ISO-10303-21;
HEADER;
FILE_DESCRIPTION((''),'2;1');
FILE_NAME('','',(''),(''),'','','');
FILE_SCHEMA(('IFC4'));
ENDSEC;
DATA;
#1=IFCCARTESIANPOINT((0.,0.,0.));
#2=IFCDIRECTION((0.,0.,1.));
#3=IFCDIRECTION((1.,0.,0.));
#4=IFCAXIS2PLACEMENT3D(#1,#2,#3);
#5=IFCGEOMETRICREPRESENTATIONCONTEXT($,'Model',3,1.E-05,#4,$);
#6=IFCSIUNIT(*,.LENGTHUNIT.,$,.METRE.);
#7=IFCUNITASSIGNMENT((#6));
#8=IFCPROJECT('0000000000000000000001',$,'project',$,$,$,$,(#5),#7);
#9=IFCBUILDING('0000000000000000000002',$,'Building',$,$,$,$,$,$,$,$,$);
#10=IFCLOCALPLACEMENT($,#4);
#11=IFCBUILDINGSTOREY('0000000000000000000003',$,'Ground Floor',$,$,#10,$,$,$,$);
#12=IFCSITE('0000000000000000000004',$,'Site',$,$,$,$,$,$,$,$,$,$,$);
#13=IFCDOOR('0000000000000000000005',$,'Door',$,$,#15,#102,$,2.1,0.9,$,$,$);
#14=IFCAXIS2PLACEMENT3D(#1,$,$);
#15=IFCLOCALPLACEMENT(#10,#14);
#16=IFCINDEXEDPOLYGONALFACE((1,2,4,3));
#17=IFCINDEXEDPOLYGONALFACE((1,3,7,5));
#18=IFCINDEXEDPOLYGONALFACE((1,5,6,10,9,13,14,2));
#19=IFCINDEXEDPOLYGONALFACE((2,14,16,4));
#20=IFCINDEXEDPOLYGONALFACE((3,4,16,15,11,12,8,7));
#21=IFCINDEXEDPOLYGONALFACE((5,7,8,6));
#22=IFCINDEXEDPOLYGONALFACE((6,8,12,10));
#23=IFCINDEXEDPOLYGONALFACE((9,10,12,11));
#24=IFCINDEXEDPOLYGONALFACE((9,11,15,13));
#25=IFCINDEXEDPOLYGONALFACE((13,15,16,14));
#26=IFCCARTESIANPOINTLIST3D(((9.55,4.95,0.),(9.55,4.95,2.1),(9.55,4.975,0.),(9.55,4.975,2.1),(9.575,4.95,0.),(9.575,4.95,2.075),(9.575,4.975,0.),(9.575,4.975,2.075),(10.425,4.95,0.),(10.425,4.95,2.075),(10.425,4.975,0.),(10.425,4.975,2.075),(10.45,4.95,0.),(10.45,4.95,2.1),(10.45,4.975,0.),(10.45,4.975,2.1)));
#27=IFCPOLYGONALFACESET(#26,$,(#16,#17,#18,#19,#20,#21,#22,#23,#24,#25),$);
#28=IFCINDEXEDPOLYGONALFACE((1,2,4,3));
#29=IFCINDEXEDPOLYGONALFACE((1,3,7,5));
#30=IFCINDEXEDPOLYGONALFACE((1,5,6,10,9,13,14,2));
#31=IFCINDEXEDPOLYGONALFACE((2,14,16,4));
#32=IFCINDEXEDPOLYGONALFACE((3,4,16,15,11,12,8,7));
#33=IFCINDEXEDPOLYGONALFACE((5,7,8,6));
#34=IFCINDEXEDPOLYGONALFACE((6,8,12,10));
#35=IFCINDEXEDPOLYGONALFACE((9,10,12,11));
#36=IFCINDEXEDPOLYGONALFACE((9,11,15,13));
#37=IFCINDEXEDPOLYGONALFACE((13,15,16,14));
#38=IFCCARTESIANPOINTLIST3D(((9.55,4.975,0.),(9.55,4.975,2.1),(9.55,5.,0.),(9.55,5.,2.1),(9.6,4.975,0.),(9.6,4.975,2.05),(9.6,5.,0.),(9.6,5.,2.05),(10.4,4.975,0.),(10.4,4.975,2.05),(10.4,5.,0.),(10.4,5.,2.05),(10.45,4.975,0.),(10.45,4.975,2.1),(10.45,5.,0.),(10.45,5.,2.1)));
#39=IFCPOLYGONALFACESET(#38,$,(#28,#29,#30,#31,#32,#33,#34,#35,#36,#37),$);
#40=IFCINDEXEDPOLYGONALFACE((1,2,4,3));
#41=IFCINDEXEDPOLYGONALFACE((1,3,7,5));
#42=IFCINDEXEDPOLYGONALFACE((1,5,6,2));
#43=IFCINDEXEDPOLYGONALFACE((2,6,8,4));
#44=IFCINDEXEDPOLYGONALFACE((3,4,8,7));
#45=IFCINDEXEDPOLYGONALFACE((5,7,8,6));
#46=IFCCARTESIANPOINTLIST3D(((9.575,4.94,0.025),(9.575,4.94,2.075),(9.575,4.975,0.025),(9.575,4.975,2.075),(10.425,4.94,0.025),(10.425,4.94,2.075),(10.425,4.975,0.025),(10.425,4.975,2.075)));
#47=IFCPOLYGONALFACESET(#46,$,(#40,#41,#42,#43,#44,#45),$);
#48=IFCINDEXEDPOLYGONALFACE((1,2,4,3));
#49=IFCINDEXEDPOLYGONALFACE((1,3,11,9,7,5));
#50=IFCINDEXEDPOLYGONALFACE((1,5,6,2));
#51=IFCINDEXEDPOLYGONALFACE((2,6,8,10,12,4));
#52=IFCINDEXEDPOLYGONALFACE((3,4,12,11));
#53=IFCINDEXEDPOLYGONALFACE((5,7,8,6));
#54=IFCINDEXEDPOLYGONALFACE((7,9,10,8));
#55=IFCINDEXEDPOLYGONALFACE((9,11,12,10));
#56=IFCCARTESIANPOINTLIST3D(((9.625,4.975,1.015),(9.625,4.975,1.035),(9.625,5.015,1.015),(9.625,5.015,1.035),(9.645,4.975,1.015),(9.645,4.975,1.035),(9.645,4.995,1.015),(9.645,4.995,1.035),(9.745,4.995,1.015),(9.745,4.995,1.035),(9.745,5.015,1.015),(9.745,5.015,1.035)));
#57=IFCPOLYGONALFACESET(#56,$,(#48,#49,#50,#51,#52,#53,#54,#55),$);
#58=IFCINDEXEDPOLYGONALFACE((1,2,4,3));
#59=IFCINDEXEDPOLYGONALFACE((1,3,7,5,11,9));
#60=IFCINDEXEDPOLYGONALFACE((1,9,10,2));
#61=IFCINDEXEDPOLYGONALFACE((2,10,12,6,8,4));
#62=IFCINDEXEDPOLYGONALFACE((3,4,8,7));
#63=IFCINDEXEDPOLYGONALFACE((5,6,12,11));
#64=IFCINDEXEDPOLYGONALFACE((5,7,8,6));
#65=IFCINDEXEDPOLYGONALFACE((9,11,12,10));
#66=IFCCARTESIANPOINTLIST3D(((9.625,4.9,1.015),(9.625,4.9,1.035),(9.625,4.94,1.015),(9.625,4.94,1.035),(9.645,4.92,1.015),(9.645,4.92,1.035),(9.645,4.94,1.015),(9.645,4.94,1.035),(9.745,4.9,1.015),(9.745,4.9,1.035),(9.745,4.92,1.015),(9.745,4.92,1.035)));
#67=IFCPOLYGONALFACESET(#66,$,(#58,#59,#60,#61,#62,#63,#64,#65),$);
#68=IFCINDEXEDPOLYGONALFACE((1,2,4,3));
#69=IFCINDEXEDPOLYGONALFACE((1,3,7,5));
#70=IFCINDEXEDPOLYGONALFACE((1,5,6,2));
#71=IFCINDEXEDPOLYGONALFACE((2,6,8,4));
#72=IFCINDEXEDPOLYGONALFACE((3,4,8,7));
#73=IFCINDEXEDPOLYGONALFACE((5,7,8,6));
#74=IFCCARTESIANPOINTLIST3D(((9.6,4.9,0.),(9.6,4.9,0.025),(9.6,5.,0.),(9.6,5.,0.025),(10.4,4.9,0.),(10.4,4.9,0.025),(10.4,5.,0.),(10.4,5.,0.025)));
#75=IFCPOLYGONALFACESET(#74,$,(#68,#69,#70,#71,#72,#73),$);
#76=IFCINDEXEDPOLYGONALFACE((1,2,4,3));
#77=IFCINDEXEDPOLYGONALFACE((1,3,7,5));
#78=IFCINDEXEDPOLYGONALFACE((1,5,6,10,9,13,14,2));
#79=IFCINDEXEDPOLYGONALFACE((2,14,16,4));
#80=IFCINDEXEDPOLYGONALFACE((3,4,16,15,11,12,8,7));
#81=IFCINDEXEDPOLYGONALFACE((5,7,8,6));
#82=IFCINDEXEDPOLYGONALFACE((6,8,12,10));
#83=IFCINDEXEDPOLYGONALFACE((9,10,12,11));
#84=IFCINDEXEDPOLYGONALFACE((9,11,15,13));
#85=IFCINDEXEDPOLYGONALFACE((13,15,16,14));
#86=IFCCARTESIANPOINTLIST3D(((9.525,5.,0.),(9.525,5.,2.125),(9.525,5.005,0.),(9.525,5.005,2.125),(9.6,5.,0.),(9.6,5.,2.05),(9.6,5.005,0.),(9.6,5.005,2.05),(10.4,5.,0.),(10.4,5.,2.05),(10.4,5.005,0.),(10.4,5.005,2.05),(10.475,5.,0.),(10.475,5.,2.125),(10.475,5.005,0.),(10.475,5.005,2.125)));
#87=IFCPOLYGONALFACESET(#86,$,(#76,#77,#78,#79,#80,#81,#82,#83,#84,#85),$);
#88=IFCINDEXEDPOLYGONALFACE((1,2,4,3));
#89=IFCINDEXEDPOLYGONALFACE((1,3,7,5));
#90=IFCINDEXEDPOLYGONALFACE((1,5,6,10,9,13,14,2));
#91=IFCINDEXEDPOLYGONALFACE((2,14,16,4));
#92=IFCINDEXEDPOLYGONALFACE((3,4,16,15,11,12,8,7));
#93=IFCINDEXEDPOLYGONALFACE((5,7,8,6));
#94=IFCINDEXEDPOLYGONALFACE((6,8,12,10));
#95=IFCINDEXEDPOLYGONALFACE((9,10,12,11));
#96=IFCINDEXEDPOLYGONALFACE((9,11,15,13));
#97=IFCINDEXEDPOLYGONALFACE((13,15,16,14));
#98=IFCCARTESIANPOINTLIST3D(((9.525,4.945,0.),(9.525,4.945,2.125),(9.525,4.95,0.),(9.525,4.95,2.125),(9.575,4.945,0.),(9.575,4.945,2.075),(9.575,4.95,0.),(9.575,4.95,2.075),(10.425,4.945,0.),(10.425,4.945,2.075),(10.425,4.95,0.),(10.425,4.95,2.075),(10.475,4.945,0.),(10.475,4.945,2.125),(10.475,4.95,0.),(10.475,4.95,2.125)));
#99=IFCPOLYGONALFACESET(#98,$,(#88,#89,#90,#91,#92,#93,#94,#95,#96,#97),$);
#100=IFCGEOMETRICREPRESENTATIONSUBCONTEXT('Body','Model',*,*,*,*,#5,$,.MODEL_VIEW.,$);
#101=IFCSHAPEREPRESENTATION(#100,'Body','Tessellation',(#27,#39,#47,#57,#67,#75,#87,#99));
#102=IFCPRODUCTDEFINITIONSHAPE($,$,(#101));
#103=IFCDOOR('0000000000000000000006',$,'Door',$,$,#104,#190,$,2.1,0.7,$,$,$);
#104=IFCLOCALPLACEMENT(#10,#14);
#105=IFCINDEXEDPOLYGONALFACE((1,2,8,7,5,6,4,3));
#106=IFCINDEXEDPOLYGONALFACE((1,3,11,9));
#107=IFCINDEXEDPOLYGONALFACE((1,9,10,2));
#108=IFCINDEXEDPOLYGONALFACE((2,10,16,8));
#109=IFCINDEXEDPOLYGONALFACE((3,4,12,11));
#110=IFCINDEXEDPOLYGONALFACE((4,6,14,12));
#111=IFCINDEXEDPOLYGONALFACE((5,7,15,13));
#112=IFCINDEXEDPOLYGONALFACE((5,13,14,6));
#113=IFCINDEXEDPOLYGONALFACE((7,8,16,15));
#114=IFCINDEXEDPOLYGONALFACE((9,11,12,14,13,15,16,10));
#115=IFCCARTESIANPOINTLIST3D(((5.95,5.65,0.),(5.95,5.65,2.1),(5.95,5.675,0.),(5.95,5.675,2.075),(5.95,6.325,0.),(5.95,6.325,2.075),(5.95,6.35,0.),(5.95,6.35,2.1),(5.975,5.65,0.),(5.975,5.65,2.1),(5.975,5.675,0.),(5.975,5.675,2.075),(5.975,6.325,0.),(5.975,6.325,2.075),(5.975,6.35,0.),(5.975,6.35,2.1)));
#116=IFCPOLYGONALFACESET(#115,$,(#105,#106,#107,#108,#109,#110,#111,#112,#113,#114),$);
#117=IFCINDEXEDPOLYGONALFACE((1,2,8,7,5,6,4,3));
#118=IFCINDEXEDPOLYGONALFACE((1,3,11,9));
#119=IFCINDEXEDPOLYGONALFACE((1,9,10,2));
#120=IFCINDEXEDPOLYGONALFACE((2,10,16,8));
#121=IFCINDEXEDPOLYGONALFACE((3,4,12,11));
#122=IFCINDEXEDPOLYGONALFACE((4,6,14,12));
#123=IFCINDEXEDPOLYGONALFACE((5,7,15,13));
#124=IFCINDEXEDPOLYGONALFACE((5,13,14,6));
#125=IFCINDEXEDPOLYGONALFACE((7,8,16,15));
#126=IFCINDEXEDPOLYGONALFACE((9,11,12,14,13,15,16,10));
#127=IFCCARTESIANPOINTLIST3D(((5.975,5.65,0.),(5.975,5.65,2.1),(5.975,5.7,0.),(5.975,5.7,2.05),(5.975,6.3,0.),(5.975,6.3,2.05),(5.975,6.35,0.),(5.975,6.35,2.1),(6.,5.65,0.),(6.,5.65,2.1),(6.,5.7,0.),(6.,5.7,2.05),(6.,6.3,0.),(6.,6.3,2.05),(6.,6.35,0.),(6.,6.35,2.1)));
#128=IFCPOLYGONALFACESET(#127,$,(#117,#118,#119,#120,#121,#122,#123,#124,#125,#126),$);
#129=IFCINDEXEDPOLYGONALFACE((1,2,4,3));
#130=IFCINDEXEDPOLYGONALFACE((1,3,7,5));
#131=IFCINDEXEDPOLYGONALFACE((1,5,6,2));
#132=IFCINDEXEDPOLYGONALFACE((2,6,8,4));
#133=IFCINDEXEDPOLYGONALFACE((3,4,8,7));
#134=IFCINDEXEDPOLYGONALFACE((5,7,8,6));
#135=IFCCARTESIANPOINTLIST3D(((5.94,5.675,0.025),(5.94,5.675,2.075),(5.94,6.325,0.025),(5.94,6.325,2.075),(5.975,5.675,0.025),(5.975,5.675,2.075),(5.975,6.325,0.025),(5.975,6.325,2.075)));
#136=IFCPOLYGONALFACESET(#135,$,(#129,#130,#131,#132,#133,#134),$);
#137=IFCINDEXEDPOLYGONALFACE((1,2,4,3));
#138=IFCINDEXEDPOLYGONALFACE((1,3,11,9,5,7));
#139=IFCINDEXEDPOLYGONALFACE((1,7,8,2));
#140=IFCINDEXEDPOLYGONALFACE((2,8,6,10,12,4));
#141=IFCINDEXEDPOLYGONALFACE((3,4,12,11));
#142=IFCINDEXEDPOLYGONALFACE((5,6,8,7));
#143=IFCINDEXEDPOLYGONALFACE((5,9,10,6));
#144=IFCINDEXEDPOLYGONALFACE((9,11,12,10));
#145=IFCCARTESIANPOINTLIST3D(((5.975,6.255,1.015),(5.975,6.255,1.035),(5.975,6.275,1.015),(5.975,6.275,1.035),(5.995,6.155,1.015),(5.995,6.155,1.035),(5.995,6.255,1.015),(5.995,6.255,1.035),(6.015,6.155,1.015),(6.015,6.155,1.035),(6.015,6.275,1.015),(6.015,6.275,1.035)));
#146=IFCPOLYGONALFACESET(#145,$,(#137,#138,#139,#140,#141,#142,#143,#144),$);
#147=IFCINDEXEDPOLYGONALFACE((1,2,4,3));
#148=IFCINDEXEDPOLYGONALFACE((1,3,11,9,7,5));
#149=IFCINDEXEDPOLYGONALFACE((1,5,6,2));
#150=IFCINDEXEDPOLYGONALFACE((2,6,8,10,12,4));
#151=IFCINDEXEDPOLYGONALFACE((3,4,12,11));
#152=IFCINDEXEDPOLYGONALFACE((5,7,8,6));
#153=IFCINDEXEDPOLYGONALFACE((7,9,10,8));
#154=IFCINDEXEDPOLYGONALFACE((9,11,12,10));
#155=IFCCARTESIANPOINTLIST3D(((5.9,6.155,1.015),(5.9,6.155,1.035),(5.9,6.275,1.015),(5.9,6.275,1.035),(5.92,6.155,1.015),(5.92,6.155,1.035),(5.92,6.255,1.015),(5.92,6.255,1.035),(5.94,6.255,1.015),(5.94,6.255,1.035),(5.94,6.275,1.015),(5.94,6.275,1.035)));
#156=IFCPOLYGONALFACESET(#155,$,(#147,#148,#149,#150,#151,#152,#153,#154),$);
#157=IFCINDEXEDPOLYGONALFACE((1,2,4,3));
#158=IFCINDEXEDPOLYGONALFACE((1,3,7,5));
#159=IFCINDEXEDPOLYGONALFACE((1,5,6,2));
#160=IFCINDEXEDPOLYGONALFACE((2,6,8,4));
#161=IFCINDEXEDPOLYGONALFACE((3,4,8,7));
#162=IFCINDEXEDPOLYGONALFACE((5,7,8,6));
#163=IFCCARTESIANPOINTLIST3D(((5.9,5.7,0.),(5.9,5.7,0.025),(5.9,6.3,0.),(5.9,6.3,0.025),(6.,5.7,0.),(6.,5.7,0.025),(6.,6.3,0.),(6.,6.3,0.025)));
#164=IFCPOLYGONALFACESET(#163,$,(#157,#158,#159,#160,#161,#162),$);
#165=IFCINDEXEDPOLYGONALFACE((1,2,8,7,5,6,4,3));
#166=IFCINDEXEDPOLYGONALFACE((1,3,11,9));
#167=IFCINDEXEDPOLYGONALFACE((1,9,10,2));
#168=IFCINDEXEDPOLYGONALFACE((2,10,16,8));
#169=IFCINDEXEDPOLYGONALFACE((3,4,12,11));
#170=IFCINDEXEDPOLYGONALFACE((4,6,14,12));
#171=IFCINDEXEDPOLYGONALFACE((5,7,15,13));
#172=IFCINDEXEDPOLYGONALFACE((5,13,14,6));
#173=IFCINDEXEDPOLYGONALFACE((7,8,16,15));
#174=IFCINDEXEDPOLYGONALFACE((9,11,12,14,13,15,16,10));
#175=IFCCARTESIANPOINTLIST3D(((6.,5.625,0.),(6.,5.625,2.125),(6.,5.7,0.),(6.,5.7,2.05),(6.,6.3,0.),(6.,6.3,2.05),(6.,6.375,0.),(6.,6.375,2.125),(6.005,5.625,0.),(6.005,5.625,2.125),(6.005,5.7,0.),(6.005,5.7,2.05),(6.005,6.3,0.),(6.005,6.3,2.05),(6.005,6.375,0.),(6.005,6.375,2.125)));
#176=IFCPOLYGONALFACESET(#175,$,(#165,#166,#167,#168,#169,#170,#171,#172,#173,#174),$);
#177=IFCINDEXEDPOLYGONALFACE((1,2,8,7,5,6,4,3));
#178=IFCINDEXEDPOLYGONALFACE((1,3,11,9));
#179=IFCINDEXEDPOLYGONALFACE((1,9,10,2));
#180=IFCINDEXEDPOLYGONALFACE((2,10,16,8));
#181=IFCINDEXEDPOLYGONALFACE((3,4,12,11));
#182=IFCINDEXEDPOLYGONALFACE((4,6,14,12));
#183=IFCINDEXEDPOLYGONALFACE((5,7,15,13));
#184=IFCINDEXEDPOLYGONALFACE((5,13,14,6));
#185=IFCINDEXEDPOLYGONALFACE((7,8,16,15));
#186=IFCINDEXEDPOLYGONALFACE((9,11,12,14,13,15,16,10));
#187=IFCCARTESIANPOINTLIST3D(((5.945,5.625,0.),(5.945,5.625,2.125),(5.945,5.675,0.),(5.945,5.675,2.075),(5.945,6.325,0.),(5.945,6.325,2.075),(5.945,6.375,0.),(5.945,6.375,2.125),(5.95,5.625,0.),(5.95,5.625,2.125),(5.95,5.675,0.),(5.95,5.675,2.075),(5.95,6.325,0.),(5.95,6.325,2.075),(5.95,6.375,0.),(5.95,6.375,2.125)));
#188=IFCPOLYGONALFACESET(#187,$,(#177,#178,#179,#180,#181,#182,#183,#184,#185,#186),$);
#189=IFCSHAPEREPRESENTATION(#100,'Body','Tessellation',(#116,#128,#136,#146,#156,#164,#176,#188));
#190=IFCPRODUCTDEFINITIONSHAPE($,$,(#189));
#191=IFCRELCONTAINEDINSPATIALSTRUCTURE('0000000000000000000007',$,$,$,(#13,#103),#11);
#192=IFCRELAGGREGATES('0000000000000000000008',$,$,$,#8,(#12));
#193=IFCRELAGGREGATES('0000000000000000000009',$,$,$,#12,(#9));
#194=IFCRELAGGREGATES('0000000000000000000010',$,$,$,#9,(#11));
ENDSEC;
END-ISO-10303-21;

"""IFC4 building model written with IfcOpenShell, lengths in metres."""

from ifc_helpers import new_model, si_unit, frame, origin_with_axes, place, context, subcontext, project, spatial, line, indexed_curve, outline, extrude, element, save


model = new_model("IFC4")

# Units and contexts
model_context = context("Model", 3, precision=1e-05, world=origin_with_axes())
body_context = subcontext(model_context, "Body", "Model", "MODEL_VIEW")
ifc_project = project(units=[si_unit("LENGTHUNIT", "METRE")], contexts=[model_context])

# Site, building, storey
site = spatial("IfcSite", under=ifc_project, Name="Site")
building = spatial("IfcBuilding", under=site, Name="Building")
storey_placement = place(None, origin_with_axes())
storey = spatial("IfcBuildingStorey", under=building, at=storey_placement, Name="Ground Floor")

# Doors
door_1_placement = place(storey_placement, frame((10.45, 5.0, 0.0), z_axis=(0.0, 0.0, 1.0), x_axis=(-1.0, 0.0, 0.0)))
element("IfcDoor", 1, at=door_1_placement, inside=storey, Name="Door", OverallHeight=2.1, OverallWidth=0.9, context=body_context, shape_type="SweptSolid", body=[
    extrude(outline(indexed_curve([(0.0, 0.0), (0.0, 2.1), (0.9, 2.1), (0.9, 0.0), (0.875, 0.0), (0.875, 2.075), (0.025, 2.075), (0.025, 0.0)], segments=[line(1, 2, 3, 4, 5, 6, 7, 8, 1)])), frame((0.0, 0.025, 0.0), z_axis=(0.0, -1.0, 0.0), x_axis=(1.0, 0.0, 0.0)), (0.0, 0.0, -1.0), 0.025),
    extrude(outline(indexed_curve([(0.0, 0.0), (0.0, 2.1), (0.9, 2.1), (0.9, 0.0), (0.85, 0.0), (0.85, 2.05), (0.05, 2.05), (0.05, 0.0)], segments=[line(1, 2, 3, 4, 5, 6, 7, 8, 1)])), frame((0.0, 0.0, 0.0), z_axis=(0.0, -1.0, 0.0), x_axis=(1.0, 0.0, 0.0)), (0.0, 0.0, -1.0), 0.025),
    extrude(outline(indexed_curve([(0.0, 0.0), (0.85, 0.0), (0.85, 0.035), (0.0, 0.035)], segments=[line(1, 2, 3, 4, 1)])), frame((0.025, 0.025, 0.025), z_axis=(0.0, 0.0, 1.0), x_axis=(1.0, 0.0, 0.0)), (0.0, 0.0, 1.0), 2.05),
    extrude(outline(indexed_curve([(0.0, 0.0), (0.0, -0.04), (-0.12, -0.04), (-0.12, -0.02), (-0.02, -0.02), (-0.02, 0.0)], segments=[line(1, 2, 3, 4, 5, 6, 1)])), frame((0.825, 0.025, 1.015), z_axis=(0.0, 0.0, 1.0), x_axis=(1.0, 0.0, 0.0)), (0.0, 0.0, 1.0), 0.02),
    extrude(outline(indexed_curve([(0.0, 0.0), (0.0, 0.04), (-0.12, 0.04), (-0.12, 0.02), (-0.02, 0.02), (-0.02, 0.0)], segments=[line(1, 2, 3, 4, 5, 6, 1)])), frame((0.825, 0.06, 1.015), z_axis=(0.0, 0.0, 1.0), x_axis=(1.0, 0.0, 0.0)), (0.0, 0.0, 1.0), 0.02),
    extrude(outline(indexed_curve([(0.0, 0.0), (0.8, 0.0), (0.8, 0.1), (0.0, 0.1)], segments=[line(1, 2, 3, 4, 1)])), frame((0.05, 0.0, 0.0), z_axis=(0.0, 0.0, 1.0), x_axis=(1.0, 0.0, 0.0)), (0.0, 0.0, 1.0), 0.025),
    extrude(outline(indexed_curve([(0.0, 0.0), (0.0, 2.125), (0.95, 2.125), (0.95, 0.0), (0.875, 0.0), (0.875, 2.05), (0.075, 2.05), (0.075, 0.0)], segments=[line(1, 2, 3, 4, 5, 6, 7, 8, 1)])), frame((-0.025, -0.005, 0.0), z_axis=(0.0, -1.0, 0.0), x_axis=(1.0, 0.0, 0.0)), (0.0, 0.0, -1.0), 0.005),
    extrude(outline(indexed_curve([(0.0, 0.0), (0.0, 2.125), (0.95, 2.125), (0.95, 0.0), (0.9, 0.0), (0.9, 2.075), (0.05, 2.075), (0.05, 0.0)], segments=[line(1, 2, 3, 4, 5, 6, 7, 8, 1)])), frame((-0.025, 0.05, 0.0), z_axis=(0.0, -1.0, 0.0), x_axis=(1.0, 0.0, 0.0)), (0.0, 0.0, -1.0), 0.005),
])
door_2_placement = place(storey_placement, frame((6.0, 5.65, 0.0), z_axis=(0.0, 0.0, 1.0), x_axis=(0.0, 1.0, 0.0)))
element("IfcDoor", 2, at=door_2_placement, inside=storey, Name="Door", OverallHeight=2.1, OverallWidth=0.7, context=body_context, shape_type="SweptSolid", body=[
    extrude(outline(indexed_curve([(0.0, 0.0), (0.0, 2.1), (0.7, 2.1), (0.7, 0.0), (0.675, 0.0), (0.675, 2.075), (0.025, 2.075), (0.025, 0.0)], segments=[line(1, 2, 3, 4, 5, 6, 7, 8, 1)])), frame((0.0, 0.025, 0.0), z_axis=(0.0, -1.0, 0.0), x_axis=(1.0, 0.0, 0.0)), (0.0, 0.0, -1.0), 0.025),
    extrude(outline(indexed_curve([(0.0, 0.0), (0.0, 2.1), (0.7, 2.1), (0.7, 0.0), (0.65, 0.0), (0.65, 2.05), (0.05, 2.05), (0.05, 0.0)], segments=[line(1, 2, 3, 4, 5, 6, 7, 8, 1)])), frame((0.0, 0.0, 0.0), z_axis=(0.0, -1.0, 0.0), x_axis=(1.0, 0.0, 0.0)), (0.0, 0.0, -1.0), 0.025),
    extrude(outline(indexed_curve([(0.0, 0.0), (0.65, 0.0), (0.65, 0.035), (0.0, 0.035)], segments=[line(1, 2, 3, 4, 1)])), frame((0.025, 0.025, 0.025), z_axis=(0.0, 0.0, 1.0), x_axis=(1.0, 0.0, 0.0)), (0.0, 0.0, 1.0), 2.05),
    extrude(outline(indexed_curve([(0.0, 0.0), (0.0, -0.04), (-0.12, -0.04), (-0.12, -0.02), (-0.02, -0.02), (-0.02, 0.0)], segments=[line(1, 2, 3, 4, 5, 6, 1)])), frame((0.625, 0.025, 1.015), z_axis=(0.0, 0.0, 1.0), x_axis=(1.0, 0.0, 0.0)), (0.0, 0.0, 1.0), 0.02),
    extrude(outline(indexed_curve([(0.0, 0.0), (0.0, 0.04), (-0.12, 0.04), (-0.12, 0.02), (-0.02, 0.02), (-0.02, 0.0)], segments=[line(1, 2, 3, 4, 5, 6, 1)])), frame((0.625, 0.06, 1.015), z_axis=(0.0, 0.0, 1.0), x_axis=(1.0, 0.0, 0.0)), (0.0, 0.0, 1.0), 0.02),
    extrude(outline(indexed_curve([(0.0, 0.0), (0.6, 0.0), (0.6, 0.1), (0.0, 0.1)], segments=[line(1, 2, 3, 4, 1)])), frame((0.05, 0.0, 0.0), z_axis=(0.0, 0.0, 1.0), x_axis=(1.0, 0.0, 0.0)), (0.0, 0.0, 1.0), 0.025),
    extrude(outline(indexed_curve([(0.0, 0.0), (0.0, 2.125), (0.75, 2.125), (0.75, 0.0), (0.675, 0.0), (0.675, 2.05), (0.075, 2.05), (0.075, 0.0)], segments=[line(1, 2, 3, 4, 5, 6, 7, 8, 1)])), frame((-0.025, -0.005, 0.0), z_axis=(0.0, -1.0, 0.0), x_axis=(1.0, 0.0, 0.0)), (0.0, 0.0, -1.0), 0.005),
    extrude(outline(indexed_curve([(0.0, 0.0), (0.0, 2.125), (0.75, 2.125), (0.75, 0.0), (0.7, 0.0), (0.7, 2.075), (0.05, 2.075), (0.05, 0.0)], segments=[line(1, 2, 3, 4, 5, 6, 7, 8, 1)])), frame((-0.025, 0.05, 0.0), z_axis=(0.0, -1.0, 0.0), x_axis=(1.0, 0.0, 0.0)), (0.0, 0.0, -1.0), 0.005),
])

save(model, "model.ifc")
